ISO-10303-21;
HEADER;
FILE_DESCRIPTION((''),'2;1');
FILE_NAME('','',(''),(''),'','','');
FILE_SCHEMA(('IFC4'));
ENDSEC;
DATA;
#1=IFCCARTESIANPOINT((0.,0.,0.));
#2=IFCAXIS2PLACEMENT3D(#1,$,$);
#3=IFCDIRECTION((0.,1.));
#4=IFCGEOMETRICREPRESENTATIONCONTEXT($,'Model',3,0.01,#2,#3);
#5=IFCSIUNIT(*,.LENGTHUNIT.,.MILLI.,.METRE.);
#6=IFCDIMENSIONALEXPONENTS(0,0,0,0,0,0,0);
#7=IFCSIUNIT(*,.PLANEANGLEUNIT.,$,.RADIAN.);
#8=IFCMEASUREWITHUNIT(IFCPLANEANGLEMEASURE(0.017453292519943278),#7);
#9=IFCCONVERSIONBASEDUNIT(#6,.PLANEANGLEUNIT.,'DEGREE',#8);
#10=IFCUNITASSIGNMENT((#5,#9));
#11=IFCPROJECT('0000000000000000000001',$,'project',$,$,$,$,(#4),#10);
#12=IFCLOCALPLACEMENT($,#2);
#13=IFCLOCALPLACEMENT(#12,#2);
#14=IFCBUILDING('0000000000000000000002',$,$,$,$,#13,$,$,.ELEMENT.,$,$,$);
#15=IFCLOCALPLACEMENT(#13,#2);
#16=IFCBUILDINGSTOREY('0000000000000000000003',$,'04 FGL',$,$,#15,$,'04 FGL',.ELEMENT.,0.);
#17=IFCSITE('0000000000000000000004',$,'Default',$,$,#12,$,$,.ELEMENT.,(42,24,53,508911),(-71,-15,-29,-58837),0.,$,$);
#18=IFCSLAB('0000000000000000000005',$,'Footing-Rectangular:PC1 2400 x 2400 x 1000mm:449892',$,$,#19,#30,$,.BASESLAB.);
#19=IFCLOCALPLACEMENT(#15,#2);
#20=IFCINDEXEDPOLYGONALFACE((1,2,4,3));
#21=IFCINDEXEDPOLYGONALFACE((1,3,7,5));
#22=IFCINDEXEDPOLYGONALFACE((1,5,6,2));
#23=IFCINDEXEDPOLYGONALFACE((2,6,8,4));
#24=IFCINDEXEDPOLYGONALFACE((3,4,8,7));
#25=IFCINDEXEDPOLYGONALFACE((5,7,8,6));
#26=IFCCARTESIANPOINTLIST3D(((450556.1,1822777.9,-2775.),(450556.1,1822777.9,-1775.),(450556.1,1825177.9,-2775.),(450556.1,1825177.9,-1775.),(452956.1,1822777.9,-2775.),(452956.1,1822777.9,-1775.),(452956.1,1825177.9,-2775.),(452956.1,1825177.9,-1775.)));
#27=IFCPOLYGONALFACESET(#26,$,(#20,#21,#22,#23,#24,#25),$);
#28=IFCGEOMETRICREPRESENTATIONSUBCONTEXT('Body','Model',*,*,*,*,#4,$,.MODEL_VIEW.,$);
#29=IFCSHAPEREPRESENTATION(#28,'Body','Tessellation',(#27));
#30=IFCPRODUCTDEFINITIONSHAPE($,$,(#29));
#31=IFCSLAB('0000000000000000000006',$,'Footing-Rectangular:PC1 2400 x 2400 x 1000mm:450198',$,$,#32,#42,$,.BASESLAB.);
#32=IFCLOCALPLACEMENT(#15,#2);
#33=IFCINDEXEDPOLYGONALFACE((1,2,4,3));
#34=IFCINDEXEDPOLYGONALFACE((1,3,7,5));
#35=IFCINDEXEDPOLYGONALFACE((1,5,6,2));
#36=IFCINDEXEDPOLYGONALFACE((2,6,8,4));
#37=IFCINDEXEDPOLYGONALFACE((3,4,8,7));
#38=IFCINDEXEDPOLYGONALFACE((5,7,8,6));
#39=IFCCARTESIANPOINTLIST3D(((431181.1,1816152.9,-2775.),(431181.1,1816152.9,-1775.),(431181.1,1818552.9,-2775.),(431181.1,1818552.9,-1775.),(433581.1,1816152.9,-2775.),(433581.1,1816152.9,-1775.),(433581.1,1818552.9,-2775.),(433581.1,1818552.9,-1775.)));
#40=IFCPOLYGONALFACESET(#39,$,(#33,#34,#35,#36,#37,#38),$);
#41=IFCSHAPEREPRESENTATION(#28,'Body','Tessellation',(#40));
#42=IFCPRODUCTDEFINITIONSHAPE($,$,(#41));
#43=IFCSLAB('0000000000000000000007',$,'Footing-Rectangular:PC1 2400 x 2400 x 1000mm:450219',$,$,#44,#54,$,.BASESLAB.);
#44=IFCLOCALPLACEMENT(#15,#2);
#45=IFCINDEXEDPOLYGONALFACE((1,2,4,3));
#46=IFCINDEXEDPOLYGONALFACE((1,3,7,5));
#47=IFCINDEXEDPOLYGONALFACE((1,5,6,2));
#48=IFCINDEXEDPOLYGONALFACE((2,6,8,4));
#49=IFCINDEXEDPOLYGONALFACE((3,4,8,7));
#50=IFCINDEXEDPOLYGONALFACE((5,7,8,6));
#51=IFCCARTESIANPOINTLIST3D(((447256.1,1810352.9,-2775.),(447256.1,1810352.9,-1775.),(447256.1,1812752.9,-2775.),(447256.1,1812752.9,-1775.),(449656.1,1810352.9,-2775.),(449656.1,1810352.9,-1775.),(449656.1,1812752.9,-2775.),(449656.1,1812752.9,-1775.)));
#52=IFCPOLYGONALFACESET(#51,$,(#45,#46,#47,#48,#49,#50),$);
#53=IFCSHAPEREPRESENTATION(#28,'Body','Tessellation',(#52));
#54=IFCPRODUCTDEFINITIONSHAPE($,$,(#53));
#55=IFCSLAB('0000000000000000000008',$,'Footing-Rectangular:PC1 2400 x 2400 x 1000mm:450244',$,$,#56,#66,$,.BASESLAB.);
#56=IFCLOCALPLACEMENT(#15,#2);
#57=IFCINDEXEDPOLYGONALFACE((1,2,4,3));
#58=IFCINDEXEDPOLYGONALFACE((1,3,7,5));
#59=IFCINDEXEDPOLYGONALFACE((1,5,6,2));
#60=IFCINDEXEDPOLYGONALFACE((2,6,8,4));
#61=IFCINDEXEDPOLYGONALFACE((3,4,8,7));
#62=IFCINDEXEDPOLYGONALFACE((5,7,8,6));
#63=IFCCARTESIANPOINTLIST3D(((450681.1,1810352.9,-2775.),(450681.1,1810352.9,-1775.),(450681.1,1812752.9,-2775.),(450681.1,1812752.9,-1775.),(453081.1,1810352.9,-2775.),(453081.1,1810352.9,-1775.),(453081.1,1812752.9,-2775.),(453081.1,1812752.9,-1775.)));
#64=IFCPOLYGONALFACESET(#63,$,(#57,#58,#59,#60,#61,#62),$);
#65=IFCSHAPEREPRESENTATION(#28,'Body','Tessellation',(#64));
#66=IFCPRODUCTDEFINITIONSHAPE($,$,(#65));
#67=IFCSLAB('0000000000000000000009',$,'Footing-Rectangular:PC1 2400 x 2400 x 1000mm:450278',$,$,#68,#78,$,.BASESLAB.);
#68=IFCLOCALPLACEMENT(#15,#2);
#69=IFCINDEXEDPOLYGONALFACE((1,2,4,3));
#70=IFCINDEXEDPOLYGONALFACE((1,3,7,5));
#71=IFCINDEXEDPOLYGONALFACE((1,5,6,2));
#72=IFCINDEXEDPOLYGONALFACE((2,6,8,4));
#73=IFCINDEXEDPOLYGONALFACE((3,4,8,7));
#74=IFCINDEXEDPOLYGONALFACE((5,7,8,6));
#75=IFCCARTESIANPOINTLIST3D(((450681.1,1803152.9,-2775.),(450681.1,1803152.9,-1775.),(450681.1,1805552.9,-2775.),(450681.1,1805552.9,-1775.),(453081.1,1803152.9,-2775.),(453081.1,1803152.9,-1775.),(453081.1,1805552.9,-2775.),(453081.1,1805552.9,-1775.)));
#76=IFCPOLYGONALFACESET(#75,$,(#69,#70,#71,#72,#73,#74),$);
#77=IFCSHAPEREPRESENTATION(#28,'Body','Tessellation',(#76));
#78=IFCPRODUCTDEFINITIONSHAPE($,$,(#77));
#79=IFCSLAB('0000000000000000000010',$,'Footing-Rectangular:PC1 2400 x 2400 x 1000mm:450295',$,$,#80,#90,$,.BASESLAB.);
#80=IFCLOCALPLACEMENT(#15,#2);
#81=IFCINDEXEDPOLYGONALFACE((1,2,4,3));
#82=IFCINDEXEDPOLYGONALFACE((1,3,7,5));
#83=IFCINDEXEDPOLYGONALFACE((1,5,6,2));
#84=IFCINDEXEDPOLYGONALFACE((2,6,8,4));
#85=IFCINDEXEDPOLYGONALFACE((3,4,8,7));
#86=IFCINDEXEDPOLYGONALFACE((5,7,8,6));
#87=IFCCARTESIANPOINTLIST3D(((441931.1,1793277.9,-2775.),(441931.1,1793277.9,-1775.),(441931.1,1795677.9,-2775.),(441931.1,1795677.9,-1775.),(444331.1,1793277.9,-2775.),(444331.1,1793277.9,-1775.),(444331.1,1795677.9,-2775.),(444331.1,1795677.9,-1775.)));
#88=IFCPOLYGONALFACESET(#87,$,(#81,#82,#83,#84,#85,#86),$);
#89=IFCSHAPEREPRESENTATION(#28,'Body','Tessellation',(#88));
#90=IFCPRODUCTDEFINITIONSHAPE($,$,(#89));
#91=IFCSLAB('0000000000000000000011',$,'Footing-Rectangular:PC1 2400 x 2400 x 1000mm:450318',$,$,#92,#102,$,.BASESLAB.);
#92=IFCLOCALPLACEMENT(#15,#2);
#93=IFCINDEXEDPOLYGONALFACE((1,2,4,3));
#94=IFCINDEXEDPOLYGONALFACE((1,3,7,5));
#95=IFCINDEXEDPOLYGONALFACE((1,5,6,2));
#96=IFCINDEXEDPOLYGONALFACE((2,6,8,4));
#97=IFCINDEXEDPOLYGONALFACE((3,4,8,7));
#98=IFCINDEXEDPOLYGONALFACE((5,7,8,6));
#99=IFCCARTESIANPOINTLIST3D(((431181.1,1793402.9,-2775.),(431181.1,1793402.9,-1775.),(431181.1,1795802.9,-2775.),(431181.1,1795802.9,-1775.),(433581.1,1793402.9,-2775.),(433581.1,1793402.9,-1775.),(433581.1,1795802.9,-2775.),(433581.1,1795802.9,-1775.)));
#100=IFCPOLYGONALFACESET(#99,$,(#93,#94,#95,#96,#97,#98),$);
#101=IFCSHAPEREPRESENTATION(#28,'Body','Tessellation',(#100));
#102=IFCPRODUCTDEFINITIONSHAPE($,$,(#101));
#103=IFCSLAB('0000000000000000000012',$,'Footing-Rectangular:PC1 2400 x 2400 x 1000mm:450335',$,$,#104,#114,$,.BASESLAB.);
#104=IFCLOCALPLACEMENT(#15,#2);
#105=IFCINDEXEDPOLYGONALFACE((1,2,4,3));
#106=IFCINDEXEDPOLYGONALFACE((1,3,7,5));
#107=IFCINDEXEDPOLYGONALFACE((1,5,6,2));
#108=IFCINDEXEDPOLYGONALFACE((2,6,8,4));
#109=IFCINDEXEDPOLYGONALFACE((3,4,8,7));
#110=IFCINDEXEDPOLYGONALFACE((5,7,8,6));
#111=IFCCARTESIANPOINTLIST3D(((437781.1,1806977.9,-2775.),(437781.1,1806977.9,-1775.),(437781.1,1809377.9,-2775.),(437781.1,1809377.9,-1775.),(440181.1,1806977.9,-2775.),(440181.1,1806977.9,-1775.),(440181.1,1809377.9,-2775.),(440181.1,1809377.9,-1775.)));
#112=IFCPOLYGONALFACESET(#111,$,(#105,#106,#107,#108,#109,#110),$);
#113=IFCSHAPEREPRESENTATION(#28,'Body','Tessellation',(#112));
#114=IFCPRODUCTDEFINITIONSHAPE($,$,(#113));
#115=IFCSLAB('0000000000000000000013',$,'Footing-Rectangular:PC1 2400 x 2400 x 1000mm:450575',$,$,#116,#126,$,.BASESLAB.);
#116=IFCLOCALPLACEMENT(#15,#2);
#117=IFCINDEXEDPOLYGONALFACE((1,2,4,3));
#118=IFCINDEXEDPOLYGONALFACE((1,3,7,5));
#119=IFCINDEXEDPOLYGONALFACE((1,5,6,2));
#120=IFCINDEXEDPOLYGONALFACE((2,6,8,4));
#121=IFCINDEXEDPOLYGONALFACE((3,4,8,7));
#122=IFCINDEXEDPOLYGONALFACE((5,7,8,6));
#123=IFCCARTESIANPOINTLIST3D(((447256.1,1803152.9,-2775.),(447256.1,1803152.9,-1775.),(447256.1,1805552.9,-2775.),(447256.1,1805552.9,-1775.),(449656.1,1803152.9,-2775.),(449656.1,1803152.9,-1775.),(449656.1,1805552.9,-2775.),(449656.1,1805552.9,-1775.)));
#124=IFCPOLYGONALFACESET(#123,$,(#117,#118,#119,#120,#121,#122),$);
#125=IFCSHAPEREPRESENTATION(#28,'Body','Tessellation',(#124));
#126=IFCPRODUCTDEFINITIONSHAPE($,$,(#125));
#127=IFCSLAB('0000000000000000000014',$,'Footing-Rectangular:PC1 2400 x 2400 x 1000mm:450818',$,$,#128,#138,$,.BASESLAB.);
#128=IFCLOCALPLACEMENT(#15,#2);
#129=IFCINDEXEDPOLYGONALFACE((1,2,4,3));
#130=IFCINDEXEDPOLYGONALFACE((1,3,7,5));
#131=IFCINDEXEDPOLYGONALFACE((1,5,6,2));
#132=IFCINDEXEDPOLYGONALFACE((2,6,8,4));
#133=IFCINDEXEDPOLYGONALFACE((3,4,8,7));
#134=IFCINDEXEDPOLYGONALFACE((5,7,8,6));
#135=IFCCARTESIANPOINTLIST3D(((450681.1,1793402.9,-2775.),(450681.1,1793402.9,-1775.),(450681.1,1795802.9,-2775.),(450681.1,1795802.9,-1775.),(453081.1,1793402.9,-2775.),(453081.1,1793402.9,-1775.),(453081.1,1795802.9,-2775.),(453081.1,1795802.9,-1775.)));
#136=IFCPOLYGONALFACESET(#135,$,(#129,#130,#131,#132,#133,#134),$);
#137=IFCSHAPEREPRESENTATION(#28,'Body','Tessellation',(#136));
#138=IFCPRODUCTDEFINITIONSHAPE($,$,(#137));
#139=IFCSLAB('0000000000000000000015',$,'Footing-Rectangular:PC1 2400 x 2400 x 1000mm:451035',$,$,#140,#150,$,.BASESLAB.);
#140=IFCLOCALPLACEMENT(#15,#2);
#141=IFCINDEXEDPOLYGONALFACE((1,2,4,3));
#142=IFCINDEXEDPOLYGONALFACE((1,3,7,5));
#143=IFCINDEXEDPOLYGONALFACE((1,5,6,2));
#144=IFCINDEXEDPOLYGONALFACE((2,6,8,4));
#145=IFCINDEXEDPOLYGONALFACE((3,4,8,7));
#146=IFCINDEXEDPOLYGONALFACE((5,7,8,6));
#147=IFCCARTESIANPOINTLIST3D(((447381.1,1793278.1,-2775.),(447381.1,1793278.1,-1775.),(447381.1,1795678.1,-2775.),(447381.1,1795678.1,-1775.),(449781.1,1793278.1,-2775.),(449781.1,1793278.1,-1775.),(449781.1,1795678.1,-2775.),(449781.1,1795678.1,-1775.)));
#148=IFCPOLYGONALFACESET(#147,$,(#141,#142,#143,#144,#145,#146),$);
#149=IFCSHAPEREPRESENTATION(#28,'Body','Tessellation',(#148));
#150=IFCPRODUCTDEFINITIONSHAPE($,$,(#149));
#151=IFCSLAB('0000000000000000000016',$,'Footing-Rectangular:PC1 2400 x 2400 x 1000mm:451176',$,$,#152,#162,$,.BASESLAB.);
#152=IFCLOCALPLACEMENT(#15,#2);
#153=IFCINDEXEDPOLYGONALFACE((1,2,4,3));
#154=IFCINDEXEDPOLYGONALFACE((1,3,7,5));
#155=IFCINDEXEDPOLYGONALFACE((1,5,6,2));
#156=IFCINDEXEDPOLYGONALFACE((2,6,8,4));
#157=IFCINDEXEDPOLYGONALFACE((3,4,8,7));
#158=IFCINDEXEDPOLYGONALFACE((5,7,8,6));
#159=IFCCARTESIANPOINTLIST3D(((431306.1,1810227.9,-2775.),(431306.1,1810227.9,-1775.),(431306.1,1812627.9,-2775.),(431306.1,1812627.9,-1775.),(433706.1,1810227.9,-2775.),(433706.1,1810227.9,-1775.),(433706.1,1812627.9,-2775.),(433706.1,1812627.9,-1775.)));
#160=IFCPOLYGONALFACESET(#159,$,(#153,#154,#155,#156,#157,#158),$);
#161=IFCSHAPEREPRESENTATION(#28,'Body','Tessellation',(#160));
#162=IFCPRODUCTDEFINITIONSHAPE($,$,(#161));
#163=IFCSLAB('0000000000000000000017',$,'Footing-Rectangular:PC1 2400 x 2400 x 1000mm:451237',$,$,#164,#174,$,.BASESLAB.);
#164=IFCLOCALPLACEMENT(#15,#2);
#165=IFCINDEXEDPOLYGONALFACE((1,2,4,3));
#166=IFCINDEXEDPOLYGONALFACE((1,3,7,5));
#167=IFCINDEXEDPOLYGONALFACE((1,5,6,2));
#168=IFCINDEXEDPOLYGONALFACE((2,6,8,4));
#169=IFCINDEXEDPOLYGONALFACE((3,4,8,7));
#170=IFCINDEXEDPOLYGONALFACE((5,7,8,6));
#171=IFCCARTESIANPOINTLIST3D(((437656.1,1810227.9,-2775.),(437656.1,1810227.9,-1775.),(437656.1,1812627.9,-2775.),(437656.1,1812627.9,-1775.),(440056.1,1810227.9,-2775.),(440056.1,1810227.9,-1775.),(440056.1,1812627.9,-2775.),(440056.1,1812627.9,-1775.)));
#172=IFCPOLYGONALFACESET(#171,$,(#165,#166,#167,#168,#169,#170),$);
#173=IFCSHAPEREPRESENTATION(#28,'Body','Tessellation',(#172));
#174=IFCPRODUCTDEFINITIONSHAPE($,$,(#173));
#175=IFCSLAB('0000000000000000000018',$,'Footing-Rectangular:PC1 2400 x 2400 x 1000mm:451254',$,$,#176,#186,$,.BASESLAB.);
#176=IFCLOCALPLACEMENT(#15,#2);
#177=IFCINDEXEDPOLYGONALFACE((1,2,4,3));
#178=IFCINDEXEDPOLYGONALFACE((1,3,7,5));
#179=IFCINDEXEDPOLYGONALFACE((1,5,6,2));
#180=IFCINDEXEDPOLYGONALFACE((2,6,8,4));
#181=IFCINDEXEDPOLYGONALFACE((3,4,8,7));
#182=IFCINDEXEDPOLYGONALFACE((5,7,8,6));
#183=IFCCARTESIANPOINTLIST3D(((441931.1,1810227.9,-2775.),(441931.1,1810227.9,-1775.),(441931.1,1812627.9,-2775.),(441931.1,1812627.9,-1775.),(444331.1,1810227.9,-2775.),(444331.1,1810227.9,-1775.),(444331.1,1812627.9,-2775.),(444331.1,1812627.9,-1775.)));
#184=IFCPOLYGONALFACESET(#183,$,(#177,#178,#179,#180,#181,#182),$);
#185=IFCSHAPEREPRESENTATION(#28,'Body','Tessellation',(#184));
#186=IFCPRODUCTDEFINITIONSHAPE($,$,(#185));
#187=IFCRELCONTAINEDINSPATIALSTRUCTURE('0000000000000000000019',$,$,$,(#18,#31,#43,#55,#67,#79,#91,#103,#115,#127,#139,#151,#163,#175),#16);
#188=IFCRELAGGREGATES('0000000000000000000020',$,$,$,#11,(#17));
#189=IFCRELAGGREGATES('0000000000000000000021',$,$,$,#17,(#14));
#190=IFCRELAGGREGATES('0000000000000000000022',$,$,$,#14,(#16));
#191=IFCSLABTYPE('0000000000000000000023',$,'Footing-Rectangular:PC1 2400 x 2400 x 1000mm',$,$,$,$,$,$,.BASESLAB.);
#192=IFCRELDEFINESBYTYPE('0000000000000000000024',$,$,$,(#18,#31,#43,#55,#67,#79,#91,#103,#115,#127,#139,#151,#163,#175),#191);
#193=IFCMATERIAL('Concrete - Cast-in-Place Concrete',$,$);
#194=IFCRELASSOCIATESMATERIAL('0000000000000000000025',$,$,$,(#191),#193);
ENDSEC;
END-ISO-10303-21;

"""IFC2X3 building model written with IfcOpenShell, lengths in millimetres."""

from ifc_helpers import new_model, entity, si_unit, converted_unit, direction, frame, origin, origin_2d_with_axis, place, context, subcontext, project, spatial, rectangle, extrude, material, type_object, element, save


model = new_model("IFC2X3")

# Units and contexts
model_context = context("Model", 3, precision=0.01, world=origin(), true_north=direction((0.0, 1.0)))
body_context = subcontext(model_context, "Body", "Model", "MODEL_VIEW")
ifc_project = project(units=[si_unit("LENGTHUNIT", "METRE", prefix="MILLI"), converted_unit("PLANEANGLEUNIT", "DEGREE", entity("IfcPlaneAngleMeasure", 0.017453292519943278), si_unit("PLANEANGLEUNIT", "RADIAN"), dimensions=[0, 0, 0, 0, 0, 0, 0])], contexts=[model_context])

# Site, building, storey
site_placement = place(None, origin())
site = spatial("IfcSite", under=ifc_project, at=site_placement, Name="Default", CompositionType="ELEMENT", RefLatitude=(42, 24, 53, 508911), RefLongitude=(-71, -15, -29, -58837), RefElevation=0.0)
building_placement = place(site_placement, origin())
building = spatial("IfcBuilding", under=site, at=building_placement, CompositionType="ELEMENT")
storey_placement = place(building_placement, origin())
storey = spatial("IfcBuildingStorey", under=building, at=storey_placement, Name="04 FGL", LongName="04 FGL", CompositionType="ELEMENT", Elevation=0.0)

# Slabs
ifc_material_1 = material(Name="Concrete - Cast-in-Place Concrete")
slab_type_1 = type_object("IfcSlabType", Name="Footing-Rectangular:PC1 2400 x 2400 x 1000mm", PredefinedType="BASESLAB", material=ifc_material_1)
slab_1_placement = place(storey_placement, origin())
element("IfcSlab", 1, at=slab_1_placement, inside=storey, type_object=slab_type_1, Name="Footing-Rectangular:PC1 2400 x 2400 x 1000mm:449892", PredefinedType="BASESLAB", context=body_context, shape_type="SweptSolid", body=[
    extrude(rectangle(XDim=2400.0, YDim=2400.0, at=origin_2d_with_axis()), frame((451756.1, 1823977.9, -2775.0), z_axis=(0.0, 0.0, 1.0), x_axis=(-1.0, 0.0, 0.0)), (0.0, 0.0, 1.0), 1000.0),
])
slab_2_placement = place(storey_placement, origin())
element("IfcSlab", 2, at=slab_2_placement, inside=storey, type_object=slab_type_1, Name="Footing-Rectangular:PC1 2400 x 2400 x 1000mm:450198", PredefinedType="BASESLAB", context=body_context, shape_type="SweptSolid", body=[
    extrude(rectangle(XDim=2400.0, YDim=2400.0, at=origin_2d_with_axis()), frame((432381.1, 1817352.9, -2775.0), z_axis=(0.0, 0.0, 1.0), x_axis=(-1.0, 0.0, 0.0)), (0.0, 0.0, 1.0), 1000.0),
])
slab_3_placement = place(storey_placement, origin())
element("IfcSlab", 3, at=slab_3_placement, inside=storey, type_object=slab_type_1, Name="Footing-Rectangular:PC1 2400 x 2400 x 1000mm:450219", PredefinedType="BASESLAB", context=body_context, shape_type="SweptSolid", body=[
    extrude(rectangle(XDim=2400.0, YDim=2400.0, at=origin_2d_with_axis()), frame((448456.1, 1811552.9, -2775.0), z_axis=(0.0, 0.0, 1.0), x_axis=(-1.0, 0.0, 0.0)), (0.0, 0.0, 1.0), 1000.0),
])
slab_4_placement = place(storey_placement, origin())
element("IfcSlab", 4, at=slab_4_placement, inside=storey, type_object=slab_type_1, Name="Footing-Rectangular:PC1 2400 x 2400 x 1000mm:450244", PredefinedType="BASESLAB", context=body_context, shape_type="SweptSolid", body=[
    extrude(rectangle(XDim=2400.0, YDim=2400.0, at=origin_2d_with_axis()), frame((451881.1, 1811552.9, -2775.0), z_axis=(0.0, 0.0, 1.0), x_axis=(-1.0, 0.0, 0.0)), (0.0, 0.0, 1.0), 1000.0),
])
slab_5_placement = place(storey_placement, origin())
element("IfcSlab", 5, at=slab_5_placement, inside=storey, type_object=slab_type_1, Name="Footing-Rectangular:PC1 2400 x 2400 x 1000mm:450278", PredefinedType="BASESLAB", context=body_context, shape_type="SweptSolid", body=[
    extrude(rectangle(XDim=2400.0, YDim=2400.0, at=origin_2d_with_axis()), frame((451881.1, 1804352.9, -2775.0), z_axis=(0.0, 0.0, 1.0), x_axis=(-1.0, 0.0, 0.0)), (0.0, 0.0, 1.0), 1000.0),
])
slab_6_placement = place(storey_placement, origin())
element("IfcSlab", 6, at=slab_6_placement, inside=storey, type_object=slab_type_1, Name="Footing-Rectangular:PC1 2400 x 2400 x 1000mm:450295", PredefinedType="BASESLAB", context=body_context, shape_type="SweptSolid", body=[
    extrude(rectangle(XDim=2400.0, YDim=2400.0, at=origin_2d_with_axis()), frame((443131.1, 1794477.9, -2775.0), z_axis=(0.0, 0.0, 1.0), x_axis=(-1.0, 0.0, 0.0)), (0.0, 0.0, 1.0), 1000.0),
])
slab_7_placement = place(storey_placement, origin())
element("IfcSlab", 7, at=slab_7_placement, inside=storey, type_object=slab_type_1, Name="Footing-Rectangular:PC1 2400 x 2400 x 1000mm:450318", PredefinedType="BASESLAB", context=body_context, shape_type="SweptSolid", body=[
    extrude(rectangle(XDim=2400.0, YDim=2400.0, at=origin_2d_with_axis()), frame((432381.1, 1794602.9, -2775.0), z_axis=(0.0, 0.0, 1.0), x_axis=(-1.0, 0.0, 0.0)), (0.0, 0.0, 1.0), 1000.0),
])
slab_8_placement = place(storey_placement, origin())
element("IfcSlab", 8, at=slab_8_placement, inside=storey, type_object=slab_type_1, Name="Footing-Rectangular:PC1 2400 x 2400 x 1000mm:450335", PredefinedType="BASESLAB", context=body_context, shape_type="SweptSolid", body=[
    extrude(rectangle(XDim=2400.0, YDim=2400.0, at=origin_2d_with_axis()), frame((438981.1, 1808177.9, -2775.0), z_axis=(0.0, 0.0, 1.0), x_axis=(-1.0, 0.0, 0.0)), (0.0, 0.0, 1.0), 1000.0),
])
slab_9_placement = place(storey_placement, origin())
element("IfcSlab", 9, at=slab_9_placement, inside=storey, type_object=slab_type_1, Name="Footing-Rectangular:PC1 2400 x 2400 x 1000mm:450575", PredefinedType="BASESLAB", context=body_context, shape_type="SweptSolid", body=[
    extrude(rectangle(XDim=2400.0, YDim=2400.0, at=origin_2d_with_axis()), frame((448456.1, 1804352.9, -2775.0), z_axis=(0.0, 0.0, 1.0), x_axis=(-1.0, 0.0, 0.0)), (0.0, 0.0, 1.0), 1000.0),
])
slab_10_placement = place(storey_placement, origin())
element("IfcSlab", 10, at=slab_10_placement, inside=storey, type_object=slab_type_1, Name="Footing-Rectangular:PC1 2400 x 2400 x 1000mm:450818", PredefinedType="BASESLAB", context=body_context, shape_type="SweptSolid", body=[
    extrude(rectangle(XDim=2400.0, YDim=2400.0, at=origin_2d_with_axis()), frame((451881.1, 1794602.9, -2775.0), z_axis=(0.0, 0.0, 1.0), x_axis=(-1.0, 0.0, 0.0)), (0.0, 0.0, 1.0), 1000.0),
])
slab_11_placement = place(storey_placement, origin())
element("IfcSlab", 11, at=slab_11_placement, inside=storey, type_object=slab_type_1, Name="Footing-Rectangular:PC1 2400 x 2400 x 1000mm:451035", PredefinedType="BASESLAB", context=body_context, shape_type="SweptSolid", body=[
    extrude(rectangle(XDim=2400.0, YDim=2400.0, at=origin_2d_with_axis()), frame((448581.1, 1794478.1, -2775.0), z_axis=(0.0, 0.0, 1.0), x_axis=(-1.0, 0.0, 0.0)), (0.0, 0.0, 1.0), 1000.0),
])
slab_12_placement = place(storey_placement, origin())
element("IfcSlab", 12, at=slab_12_placement, inside=storey, type_object=slab_type_1, Name="Footing-Rectangular:PC1 2400 x 2400 x 1000mm:451176", PredefinedType="BASESLAB", context=body_context, shape_type="SweptSolid", body=[
    extrude(rectangle(XDim=2400.0, YDim=2400.0, at=origin_2d_with_axis()), frame((432506.1, 1811427.9, -2775.0), z_axis=(0.0, 0.0, 1.0), x_axis=(-1.0, 0.0, 0.0)), (0.0, 0.0, 1.0), 1000.0),
])
slab_13_placement = place(storey_placement, origin())
element("IfcSlab", 13, at=slab_13_placement, inside=storey, type_object=slab_type_1, Name="Footing-Rectangular:PC1 2400 x 2400 x 1000mm:451237", PredefinedType="BASESLAB", context=body_context, shape_type="SweptSolid", body=[
    extrude(rectangle(XDim=2400.0, YDim=2400.0, at=origin_2d_with_axis()), frame((438856.1, 1811427.9, -2775.0), z_axis=(0.0, 0.0, 1.0), x_axis=(-1.0, 0.0, 0.0)), (0.0, 0.0, 1.0), 1000.0),
])
slab_14_placement = place(storey_placement, origin())
element("IfcSlab", 14, at=slab_14_placement, inside=storey, type_object=slab_type_1, Name="Footing-Rectangular:PC1 2400 x 2400 x 1000mm:451254", PredefinedType="BASESLAB", context=body_context, shape_type="SweptSolid", body=[
    extrude(rectangle(XDim=2400.0, YDim=2400.0, at=origin_2d_with_axis()), frame((443131.1, 1811427.9, -2775.0), z_axis=(0.0, 0.0, 1.0), x_axis=(-1.0, 0.0, 0.0)), (0.0, 0.0, 1.0), 1000.0),
])

save(model, "model.ifc")
